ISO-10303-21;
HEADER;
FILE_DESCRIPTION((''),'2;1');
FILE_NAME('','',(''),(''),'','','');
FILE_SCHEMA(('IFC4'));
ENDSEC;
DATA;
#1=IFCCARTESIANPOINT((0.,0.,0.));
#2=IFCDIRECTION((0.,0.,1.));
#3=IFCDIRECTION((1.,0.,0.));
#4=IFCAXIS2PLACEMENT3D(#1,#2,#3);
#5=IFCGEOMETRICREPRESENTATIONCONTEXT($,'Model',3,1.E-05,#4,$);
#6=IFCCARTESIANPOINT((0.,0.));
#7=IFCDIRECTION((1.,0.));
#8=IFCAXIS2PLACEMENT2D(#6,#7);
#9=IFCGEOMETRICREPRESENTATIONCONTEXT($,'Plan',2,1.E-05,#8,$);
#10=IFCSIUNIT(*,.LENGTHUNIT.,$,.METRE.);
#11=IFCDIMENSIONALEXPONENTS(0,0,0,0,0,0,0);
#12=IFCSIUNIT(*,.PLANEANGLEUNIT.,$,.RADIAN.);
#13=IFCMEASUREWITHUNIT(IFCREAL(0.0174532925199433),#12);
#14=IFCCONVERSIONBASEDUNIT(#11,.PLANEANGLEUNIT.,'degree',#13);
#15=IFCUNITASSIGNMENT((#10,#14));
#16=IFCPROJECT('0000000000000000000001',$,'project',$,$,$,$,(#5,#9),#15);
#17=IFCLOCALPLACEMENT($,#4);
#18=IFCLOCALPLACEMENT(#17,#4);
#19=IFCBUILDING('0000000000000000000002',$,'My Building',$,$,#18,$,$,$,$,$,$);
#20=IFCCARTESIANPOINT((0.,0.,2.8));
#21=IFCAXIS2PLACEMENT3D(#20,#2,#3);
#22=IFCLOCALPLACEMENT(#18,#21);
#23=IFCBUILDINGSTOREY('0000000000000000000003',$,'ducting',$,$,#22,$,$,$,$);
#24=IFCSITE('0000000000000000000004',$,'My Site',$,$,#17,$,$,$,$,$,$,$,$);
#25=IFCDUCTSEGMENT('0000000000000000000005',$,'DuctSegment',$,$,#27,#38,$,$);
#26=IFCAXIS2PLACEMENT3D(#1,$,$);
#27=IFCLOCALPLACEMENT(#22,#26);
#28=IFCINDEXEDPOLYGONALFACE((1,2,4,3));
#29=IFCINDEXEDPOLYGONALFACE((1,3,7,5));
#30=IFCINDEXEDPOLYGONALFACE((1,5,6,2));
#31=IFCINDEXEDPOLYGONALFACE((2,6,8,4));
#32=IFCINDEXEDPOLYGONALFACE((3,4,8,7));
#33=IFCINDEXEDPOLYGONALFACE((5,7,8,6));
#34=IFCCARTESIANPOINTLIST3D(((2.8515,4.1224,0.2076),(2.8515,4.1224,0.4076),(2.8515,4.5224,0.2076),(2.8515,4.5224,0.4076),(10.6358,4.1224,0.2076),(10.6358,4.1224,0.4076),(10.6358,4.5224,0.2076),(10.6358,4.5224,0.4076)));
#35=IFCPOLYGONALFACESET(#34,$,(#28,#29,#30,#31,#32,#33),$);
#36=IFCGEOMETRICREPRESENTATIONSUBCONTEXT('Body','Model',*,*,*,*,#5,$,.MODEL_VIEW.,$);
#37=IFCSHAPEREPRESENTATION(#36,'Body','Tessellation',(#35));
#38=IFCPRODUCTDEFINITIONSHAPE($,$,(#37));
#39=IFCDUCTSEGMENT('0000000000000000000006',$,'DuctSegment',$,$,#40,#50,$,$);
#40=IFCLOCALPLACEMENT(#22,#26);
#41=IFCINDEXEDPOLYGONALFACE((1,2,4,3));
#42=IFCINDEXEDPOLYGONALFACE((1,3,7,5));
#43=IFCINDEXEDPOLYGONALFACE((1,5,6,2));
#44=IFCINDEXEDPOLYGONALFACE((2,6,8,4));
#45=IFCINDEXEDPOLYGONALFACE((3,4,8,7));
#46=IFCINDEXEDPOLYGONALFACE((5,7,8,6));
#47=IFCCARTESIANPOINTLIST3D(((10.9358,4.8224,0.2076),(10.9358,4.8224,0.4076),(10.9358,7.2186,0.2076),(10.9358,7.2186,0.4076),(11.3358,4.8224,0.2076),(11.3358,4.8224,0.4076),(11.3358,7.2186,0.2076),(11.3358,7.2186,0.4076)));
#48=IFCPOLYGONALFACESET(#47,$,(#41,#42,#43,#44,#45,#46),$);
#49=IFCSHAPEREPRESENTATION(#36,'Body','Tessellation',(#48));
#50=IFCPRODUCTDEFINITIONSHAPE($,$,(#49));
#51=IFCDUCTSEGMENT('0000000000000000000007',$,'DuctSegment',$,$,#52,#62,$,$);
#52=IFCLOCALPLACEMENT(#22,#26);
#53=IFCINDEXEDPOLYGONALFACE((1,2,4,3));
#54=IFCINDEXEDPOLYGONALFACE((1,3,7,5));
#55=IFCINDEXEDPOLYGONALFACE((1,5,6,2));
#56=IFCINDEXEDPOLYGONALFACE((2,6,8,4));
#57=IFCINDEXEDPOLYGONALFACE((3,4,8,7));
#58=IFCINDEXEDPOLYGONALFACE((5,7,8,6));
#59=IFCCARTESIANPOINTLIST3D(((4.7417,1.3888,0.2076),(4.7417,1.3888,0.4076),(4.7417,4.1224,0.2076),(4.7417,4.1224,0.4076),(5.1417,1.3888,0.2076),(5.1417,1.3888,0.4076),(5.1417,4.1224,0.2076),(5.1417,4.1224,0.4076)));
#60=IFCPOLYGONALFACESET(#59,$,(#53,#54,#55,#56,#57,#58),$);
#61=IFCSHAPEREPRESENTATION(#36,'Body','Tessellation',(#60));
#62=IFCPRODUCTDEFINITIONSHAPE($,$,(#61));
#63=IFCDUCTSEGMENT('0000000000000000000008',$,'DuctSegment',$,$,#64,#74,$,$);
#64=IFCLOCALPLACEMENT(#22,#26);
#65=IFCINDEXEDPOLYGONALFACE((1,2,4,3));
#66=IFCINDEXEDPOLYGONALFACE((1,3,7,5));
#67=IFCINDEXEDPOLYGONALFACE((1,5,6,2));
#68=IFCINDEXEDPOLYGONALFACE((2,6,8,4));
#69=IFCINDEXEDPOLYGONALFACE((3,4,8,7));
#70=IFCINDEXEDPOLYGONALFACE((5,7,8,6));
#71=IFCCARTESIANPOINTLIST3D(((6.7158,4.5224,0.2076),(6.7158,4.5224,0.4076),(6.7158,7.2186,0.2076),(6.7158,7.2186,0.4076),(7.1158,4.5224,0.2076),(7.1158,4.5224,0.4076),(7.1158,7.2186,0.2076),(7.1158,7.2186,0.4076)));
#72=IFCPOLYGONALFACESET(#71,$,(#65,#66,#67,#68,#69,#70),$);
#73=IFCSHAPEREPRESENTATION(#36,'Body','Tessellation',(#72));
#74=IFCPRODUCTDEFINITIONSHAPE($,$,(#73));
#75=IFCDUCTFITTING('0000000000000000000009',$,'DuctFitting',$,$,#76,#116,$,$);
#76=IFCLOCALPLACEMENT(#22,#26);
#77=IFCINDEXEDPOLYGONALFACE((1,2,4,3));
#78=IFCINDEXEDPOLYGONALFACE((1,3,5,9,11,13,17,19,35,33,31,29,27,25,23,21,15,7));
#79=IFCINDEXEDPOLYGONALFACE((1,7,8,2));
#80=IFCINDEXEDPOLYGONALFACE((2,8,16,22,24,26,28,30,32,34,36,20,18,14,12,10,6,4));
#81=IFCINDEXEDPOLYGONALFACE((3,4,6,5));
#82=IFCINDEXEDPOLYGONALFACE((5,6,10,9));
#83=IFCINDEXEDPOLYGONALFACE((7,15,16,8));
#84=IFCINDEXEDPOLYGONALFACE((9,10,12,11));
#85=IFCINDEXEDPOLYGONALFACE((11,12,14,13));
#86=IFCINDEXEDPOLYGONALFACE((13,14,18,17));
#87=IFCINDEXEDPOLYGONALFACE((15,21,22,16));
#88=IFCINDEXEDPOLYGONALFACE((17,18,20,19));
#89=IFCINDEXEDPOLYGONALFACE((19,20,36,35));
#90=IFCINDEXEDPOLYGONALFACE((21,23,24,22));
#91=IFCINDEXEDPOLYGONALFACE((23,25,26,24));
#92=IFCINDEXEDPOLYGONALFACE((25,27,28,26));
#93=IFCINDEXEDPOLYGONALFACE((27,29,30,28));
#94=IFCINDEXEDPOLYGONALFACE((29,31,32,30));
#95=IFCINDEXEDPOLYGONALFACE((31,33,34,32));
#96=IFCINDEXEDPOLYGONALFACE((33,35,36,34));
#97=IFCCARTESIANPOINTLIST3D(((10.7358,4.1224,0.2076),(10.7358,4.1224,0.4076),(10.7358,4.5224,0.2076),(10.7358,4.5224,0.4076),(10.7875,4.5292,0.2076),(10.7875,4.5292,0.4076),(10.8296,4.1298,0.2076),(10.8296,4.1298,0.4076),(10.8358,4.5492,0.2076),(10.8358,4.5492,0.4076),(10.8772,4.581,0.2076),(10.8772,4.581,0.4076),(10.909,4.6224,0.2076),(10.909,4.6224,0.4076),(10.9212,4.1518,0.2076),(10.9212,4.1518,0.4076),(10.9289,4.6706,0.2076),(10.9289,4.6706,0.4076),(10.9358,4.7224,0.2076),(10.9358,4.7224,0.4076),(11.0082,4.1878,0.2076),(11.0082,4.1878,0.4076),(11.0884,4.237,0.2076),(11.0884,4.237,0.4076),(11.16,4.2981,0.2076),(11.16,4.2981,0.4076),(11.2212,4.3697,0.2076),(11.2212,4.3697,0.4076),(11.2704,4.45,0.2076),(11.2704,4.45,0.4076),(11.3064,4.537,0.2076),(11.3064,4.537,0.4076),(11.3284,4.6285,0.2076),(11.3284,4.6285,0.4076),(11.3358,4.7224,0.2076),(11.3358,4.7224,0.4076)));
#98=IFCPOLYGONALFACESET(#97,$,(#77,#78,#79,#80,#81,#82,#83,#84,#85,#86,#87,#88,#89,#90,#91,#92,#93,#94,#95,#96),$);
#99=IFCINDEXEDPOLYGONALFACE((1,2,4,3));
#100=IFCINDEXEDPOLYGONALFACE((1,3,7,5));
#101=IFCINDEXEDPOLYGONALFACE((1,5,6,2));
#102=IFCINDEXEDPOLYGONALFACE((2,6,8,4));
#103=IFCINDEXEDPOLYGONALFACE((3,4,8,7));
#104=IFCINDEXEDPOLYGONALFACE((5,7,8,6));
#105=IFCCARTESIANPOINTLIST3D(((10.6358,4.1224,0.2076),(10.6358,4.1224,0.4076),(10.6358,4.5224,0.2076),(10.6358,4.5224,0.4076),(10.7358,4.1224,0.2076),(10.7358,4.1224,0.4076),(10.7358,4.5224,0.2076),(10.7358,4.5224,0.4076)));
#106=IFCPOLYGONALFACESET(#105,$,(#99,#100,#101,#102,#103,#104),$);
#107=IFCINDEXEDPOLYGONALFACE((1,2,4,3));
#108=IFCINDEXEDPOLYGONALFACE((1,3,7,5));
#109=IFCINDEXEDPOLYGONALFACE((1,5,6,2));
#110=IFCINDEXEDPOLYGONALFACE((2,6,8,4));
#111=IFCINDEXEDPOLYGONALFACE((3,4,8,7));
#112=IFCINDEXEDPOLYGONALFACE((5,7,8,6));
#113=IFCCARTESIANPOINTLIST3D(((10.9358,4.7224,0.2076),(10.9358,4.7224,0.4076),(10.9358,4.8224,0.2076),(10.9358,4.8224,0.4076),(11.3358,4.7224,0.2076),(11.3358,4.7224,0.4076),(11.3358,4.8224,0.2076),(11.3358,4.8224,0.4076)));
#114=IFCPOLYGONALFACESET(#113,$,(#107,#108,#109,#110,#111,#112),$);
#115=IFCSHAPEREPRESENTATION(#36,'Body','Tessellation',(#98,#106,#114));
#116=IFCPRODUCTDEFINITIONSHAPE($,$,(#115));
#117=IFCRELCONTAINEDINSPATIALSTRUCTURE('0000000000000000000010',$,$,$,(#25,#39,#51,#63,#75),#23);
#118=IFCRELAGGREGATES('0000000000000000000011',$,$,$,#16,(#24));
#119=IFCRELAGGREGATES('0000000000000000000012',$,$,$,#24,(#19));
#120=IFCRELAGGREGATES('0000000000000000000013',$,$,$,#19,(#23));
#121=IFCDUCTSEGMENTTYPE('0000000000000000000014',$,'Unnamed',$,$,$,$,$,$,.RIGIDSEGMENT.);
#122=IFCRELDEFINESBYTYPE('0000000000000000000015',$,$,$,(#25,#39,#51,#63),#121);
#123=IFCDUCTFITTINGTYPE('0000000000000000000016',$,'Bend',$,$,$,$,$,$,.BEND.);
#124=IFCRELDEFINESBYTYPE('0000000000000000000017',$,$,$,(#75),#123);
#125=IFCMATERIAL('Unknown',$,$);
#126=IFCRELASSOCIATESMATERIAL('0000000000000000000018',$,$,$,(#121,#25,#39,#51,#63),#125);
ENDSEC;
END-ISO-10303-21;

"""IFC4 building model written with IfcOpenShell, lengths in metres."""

from ifc_helpers import new_model, entity, si_unit, converted_unit, frame, origin_with_axes, origin_2d_with_axis, place, context, subcontext, project, spatial, line, arc, indexed_curve, rectangle, outline, extrude, source, transform, mapped, material, material_profile, profile_set, profile_usage, type_object, type_shapes, element, save


model = new_model("IFC4")

# Units and contexts
model_context = context("Model", 3, precision=1e-05, world=origin_with_axes())
plan_context = context("Plan", 2, precision=1e-05, world=origin_2d_with_axis())
body_context = subcontext(model_context, "Body", "Model", "MODEL_VIEW")
ifc_project = project(units=[si_unit("LENGTHUNIT", "METRE"), converted_unit("PLANEANGLEUNIT", "degree", entity("IfcReal", 0.0174532925199433), si_unit("PLANEANGLEUNIT", "RADIAN"), dimensions=[0, 0, 0, 0, 0, 0, 0])], contexts=[model_context, plan_context])

# Site, building, storey
site_placement = place(None, origin_with_axes())
site = spatial("IfcSite", under=ifc_project, at=site_placement, Name="My Site")
building_placement = place(site_placement, origin_with_axes())
building = spatial("IfcBuilding", under=site, at=building_placement, Name="My Building")
storey_placement = place(building_placement, frame((0.0, 0.0, 2.8), z_axis=(0.0, 0.0, 1.0), x_axis=(1.0, 0.0, 0.0)))
storey = spatial("IfcBuildingStorey", under=building, at=storey_placement, Name="ducting")

# Duct segments
ifc_material = material(Name="Unknown")
ifc_material_profile = material_profile(ifc_material, rectangle(XDim=0.4, YDim=0.2))
ifc_profile_set = profile_set([ifc_material_profile])
ifc_profile_usage_1 = profile_usage(ifc_profile_set, cardinal=5)
duct_segment_type = type_object("IfcDuctSegmentType", Name="Unnamed", PredefinedType="RIGIDSEGMENT", material=ifc_profile_set)
duct_segment_1_placement = place(storey_placement, frame((2.8515, 4.3224, 0.3076), z_axis=(1.0, 0.0, 0.0), x_axis=(0.0, 1.0, 0.0)))
element("IfcDuctSegment", 1, at=duct_segment_1_placement, inside=storey, type_object=duct_segment_type, material=ifc_profile_usage_1, Name="DuctSegment", context=body_context, shape_type="SweptSolid", body=[
    extrude(rectangle(XDim=0.4, YDim=0.2), origin_with_axes(), (0.0, 0.0, 1.0), 7.7843),
])
ifc_profile_usage_2 = profile_usage(ifc_profile_set, cardinal=5)
duct_segment_2_placement = place(storey_placement, frame((11.1358, 4.8224, 0.3076), z_axis=(0.0, 1.0, 0.0), x_axis=(-1.0, 0.0, 0.0)))
element("IfcDuctSegment", 2, at=duct_segment_2_placement, inside=storey, type_object=duct_segment_type, material=ifc_profile_usage_2, Name="DuctSegment", context=body_context, shape_type="SweptSolid", body=[
    extrude(rectangle(XDim=0.4, YDim=0.2), origin_with_axes(), (0.0, 0.0, 1.0), 2.3962),
])
ifc_profile_usage_3 = profile_usage(ifc_profile_set, cardinal=5)
duct_segment_3_placement = place(storey_placement, frame((4.9417, 1.3888, 0.3076), z_axis=(0.0, 1.0, 0.0), x_axis=(-1.0, 0.0, 0.0)))
element("IfcDuctSegment", 3, at=duct_segment_3_placement, inside=storey, type_object=duct_segment_type, material=ifc_profile_usage_3, Name="DuctSegment", context=body_context, shape_type="SweptSolid", body=[
    extrude(rectangle(XDim=0.4, YDim=0.2), origin_with_axes(), (0.0, 0.0, 1.0), 2.7336),
])
ifc_profile_usage_4 = profile_usage(ifc_profile_set, cardinal=5)
duct_segment_4_placement = place(storey_placement, frame((6.9158, 4.5224, 0.3076), z_axis=(0.0, 1.0, 0.0), x_axis=(-1.0, 0.0, 0.0)))
element("IfcDuctSegment", 4, at=duct_segment_4_placement, inside=storey, type_object=duct_segment_type, material=ifc_profile_usage_4, Name="DuctSegment", context=body_context, shape_type="SweptSolid", body=[
    extrude(rectangle(XDim=0.4, YDim=0.2), origin_with_axes(), (0.0, 0.0, 1.0), 2.6962),
])

# Duct fitting
duct_fitting_type = type_object("IfcDuctFittingType", Name="Bend", PredefinedType="BEND")
shared_shape = source(origin_with_axes(), body_context, "Body", "SweptSolid", [
    extrude(outline(indexed_curve([(0.2, 0.0), (0.2586, 0.1414), (0.4, 0.2), (0.4, 0.6), (-0.0243, 0.4243), (-0.2, 0.0)], segments=[arc(1, 2, 3), line(3, 4), arc(4, 5, 6), line(6, 1)])), frame((0.0, -0.1, 0.1), z_axis=(0.0, -1.0, 0.0), x_axis=(1.0, 0.0, 0.0)), (0.0, 0.0, -1.0), 0.2),
    extrude(rectangle(XDim=0.4, YDim=0.2), origin_with_axes(), (0.0, 0.0, 1.0), 0.1),
    extrude(rectangle(XDim=0.4, YDim=0.2), frame((0.4, 0.0, 0.5), z_axis=(1.0, 0.0, 0.0), x_axis=(0.0, 0.0, 1.0)), (0.0, 0.0, 1.0), 0.1),
])
type_shapes(duct_fitting_type, [shared_shape])
duct_fitting_placement = place(storey_placement, frame((10.6358, 4.3224, 0.3076), z_axis=(1.0, 0.0, 0.0), x_axis=(0.0, 1.0, 0.0)))
element("IfcDuctFitting", 5, at=duct_fitting_placement, inside=storey, type_object=duct_fitting_type, Name="DuctFitting", context=body_context, shape_type="MappedRepresentation", body=[
    mapped(shared_shape, transform((0.0, 0.0, 0.0), x_axis=(1.0, 0.0, 0.0), y_axis=(0.0, 1.0, 0.0), z_axis=(0.0, 0.0, 1.0), scale=1.0)),
])

save(model, "model.ifc")
